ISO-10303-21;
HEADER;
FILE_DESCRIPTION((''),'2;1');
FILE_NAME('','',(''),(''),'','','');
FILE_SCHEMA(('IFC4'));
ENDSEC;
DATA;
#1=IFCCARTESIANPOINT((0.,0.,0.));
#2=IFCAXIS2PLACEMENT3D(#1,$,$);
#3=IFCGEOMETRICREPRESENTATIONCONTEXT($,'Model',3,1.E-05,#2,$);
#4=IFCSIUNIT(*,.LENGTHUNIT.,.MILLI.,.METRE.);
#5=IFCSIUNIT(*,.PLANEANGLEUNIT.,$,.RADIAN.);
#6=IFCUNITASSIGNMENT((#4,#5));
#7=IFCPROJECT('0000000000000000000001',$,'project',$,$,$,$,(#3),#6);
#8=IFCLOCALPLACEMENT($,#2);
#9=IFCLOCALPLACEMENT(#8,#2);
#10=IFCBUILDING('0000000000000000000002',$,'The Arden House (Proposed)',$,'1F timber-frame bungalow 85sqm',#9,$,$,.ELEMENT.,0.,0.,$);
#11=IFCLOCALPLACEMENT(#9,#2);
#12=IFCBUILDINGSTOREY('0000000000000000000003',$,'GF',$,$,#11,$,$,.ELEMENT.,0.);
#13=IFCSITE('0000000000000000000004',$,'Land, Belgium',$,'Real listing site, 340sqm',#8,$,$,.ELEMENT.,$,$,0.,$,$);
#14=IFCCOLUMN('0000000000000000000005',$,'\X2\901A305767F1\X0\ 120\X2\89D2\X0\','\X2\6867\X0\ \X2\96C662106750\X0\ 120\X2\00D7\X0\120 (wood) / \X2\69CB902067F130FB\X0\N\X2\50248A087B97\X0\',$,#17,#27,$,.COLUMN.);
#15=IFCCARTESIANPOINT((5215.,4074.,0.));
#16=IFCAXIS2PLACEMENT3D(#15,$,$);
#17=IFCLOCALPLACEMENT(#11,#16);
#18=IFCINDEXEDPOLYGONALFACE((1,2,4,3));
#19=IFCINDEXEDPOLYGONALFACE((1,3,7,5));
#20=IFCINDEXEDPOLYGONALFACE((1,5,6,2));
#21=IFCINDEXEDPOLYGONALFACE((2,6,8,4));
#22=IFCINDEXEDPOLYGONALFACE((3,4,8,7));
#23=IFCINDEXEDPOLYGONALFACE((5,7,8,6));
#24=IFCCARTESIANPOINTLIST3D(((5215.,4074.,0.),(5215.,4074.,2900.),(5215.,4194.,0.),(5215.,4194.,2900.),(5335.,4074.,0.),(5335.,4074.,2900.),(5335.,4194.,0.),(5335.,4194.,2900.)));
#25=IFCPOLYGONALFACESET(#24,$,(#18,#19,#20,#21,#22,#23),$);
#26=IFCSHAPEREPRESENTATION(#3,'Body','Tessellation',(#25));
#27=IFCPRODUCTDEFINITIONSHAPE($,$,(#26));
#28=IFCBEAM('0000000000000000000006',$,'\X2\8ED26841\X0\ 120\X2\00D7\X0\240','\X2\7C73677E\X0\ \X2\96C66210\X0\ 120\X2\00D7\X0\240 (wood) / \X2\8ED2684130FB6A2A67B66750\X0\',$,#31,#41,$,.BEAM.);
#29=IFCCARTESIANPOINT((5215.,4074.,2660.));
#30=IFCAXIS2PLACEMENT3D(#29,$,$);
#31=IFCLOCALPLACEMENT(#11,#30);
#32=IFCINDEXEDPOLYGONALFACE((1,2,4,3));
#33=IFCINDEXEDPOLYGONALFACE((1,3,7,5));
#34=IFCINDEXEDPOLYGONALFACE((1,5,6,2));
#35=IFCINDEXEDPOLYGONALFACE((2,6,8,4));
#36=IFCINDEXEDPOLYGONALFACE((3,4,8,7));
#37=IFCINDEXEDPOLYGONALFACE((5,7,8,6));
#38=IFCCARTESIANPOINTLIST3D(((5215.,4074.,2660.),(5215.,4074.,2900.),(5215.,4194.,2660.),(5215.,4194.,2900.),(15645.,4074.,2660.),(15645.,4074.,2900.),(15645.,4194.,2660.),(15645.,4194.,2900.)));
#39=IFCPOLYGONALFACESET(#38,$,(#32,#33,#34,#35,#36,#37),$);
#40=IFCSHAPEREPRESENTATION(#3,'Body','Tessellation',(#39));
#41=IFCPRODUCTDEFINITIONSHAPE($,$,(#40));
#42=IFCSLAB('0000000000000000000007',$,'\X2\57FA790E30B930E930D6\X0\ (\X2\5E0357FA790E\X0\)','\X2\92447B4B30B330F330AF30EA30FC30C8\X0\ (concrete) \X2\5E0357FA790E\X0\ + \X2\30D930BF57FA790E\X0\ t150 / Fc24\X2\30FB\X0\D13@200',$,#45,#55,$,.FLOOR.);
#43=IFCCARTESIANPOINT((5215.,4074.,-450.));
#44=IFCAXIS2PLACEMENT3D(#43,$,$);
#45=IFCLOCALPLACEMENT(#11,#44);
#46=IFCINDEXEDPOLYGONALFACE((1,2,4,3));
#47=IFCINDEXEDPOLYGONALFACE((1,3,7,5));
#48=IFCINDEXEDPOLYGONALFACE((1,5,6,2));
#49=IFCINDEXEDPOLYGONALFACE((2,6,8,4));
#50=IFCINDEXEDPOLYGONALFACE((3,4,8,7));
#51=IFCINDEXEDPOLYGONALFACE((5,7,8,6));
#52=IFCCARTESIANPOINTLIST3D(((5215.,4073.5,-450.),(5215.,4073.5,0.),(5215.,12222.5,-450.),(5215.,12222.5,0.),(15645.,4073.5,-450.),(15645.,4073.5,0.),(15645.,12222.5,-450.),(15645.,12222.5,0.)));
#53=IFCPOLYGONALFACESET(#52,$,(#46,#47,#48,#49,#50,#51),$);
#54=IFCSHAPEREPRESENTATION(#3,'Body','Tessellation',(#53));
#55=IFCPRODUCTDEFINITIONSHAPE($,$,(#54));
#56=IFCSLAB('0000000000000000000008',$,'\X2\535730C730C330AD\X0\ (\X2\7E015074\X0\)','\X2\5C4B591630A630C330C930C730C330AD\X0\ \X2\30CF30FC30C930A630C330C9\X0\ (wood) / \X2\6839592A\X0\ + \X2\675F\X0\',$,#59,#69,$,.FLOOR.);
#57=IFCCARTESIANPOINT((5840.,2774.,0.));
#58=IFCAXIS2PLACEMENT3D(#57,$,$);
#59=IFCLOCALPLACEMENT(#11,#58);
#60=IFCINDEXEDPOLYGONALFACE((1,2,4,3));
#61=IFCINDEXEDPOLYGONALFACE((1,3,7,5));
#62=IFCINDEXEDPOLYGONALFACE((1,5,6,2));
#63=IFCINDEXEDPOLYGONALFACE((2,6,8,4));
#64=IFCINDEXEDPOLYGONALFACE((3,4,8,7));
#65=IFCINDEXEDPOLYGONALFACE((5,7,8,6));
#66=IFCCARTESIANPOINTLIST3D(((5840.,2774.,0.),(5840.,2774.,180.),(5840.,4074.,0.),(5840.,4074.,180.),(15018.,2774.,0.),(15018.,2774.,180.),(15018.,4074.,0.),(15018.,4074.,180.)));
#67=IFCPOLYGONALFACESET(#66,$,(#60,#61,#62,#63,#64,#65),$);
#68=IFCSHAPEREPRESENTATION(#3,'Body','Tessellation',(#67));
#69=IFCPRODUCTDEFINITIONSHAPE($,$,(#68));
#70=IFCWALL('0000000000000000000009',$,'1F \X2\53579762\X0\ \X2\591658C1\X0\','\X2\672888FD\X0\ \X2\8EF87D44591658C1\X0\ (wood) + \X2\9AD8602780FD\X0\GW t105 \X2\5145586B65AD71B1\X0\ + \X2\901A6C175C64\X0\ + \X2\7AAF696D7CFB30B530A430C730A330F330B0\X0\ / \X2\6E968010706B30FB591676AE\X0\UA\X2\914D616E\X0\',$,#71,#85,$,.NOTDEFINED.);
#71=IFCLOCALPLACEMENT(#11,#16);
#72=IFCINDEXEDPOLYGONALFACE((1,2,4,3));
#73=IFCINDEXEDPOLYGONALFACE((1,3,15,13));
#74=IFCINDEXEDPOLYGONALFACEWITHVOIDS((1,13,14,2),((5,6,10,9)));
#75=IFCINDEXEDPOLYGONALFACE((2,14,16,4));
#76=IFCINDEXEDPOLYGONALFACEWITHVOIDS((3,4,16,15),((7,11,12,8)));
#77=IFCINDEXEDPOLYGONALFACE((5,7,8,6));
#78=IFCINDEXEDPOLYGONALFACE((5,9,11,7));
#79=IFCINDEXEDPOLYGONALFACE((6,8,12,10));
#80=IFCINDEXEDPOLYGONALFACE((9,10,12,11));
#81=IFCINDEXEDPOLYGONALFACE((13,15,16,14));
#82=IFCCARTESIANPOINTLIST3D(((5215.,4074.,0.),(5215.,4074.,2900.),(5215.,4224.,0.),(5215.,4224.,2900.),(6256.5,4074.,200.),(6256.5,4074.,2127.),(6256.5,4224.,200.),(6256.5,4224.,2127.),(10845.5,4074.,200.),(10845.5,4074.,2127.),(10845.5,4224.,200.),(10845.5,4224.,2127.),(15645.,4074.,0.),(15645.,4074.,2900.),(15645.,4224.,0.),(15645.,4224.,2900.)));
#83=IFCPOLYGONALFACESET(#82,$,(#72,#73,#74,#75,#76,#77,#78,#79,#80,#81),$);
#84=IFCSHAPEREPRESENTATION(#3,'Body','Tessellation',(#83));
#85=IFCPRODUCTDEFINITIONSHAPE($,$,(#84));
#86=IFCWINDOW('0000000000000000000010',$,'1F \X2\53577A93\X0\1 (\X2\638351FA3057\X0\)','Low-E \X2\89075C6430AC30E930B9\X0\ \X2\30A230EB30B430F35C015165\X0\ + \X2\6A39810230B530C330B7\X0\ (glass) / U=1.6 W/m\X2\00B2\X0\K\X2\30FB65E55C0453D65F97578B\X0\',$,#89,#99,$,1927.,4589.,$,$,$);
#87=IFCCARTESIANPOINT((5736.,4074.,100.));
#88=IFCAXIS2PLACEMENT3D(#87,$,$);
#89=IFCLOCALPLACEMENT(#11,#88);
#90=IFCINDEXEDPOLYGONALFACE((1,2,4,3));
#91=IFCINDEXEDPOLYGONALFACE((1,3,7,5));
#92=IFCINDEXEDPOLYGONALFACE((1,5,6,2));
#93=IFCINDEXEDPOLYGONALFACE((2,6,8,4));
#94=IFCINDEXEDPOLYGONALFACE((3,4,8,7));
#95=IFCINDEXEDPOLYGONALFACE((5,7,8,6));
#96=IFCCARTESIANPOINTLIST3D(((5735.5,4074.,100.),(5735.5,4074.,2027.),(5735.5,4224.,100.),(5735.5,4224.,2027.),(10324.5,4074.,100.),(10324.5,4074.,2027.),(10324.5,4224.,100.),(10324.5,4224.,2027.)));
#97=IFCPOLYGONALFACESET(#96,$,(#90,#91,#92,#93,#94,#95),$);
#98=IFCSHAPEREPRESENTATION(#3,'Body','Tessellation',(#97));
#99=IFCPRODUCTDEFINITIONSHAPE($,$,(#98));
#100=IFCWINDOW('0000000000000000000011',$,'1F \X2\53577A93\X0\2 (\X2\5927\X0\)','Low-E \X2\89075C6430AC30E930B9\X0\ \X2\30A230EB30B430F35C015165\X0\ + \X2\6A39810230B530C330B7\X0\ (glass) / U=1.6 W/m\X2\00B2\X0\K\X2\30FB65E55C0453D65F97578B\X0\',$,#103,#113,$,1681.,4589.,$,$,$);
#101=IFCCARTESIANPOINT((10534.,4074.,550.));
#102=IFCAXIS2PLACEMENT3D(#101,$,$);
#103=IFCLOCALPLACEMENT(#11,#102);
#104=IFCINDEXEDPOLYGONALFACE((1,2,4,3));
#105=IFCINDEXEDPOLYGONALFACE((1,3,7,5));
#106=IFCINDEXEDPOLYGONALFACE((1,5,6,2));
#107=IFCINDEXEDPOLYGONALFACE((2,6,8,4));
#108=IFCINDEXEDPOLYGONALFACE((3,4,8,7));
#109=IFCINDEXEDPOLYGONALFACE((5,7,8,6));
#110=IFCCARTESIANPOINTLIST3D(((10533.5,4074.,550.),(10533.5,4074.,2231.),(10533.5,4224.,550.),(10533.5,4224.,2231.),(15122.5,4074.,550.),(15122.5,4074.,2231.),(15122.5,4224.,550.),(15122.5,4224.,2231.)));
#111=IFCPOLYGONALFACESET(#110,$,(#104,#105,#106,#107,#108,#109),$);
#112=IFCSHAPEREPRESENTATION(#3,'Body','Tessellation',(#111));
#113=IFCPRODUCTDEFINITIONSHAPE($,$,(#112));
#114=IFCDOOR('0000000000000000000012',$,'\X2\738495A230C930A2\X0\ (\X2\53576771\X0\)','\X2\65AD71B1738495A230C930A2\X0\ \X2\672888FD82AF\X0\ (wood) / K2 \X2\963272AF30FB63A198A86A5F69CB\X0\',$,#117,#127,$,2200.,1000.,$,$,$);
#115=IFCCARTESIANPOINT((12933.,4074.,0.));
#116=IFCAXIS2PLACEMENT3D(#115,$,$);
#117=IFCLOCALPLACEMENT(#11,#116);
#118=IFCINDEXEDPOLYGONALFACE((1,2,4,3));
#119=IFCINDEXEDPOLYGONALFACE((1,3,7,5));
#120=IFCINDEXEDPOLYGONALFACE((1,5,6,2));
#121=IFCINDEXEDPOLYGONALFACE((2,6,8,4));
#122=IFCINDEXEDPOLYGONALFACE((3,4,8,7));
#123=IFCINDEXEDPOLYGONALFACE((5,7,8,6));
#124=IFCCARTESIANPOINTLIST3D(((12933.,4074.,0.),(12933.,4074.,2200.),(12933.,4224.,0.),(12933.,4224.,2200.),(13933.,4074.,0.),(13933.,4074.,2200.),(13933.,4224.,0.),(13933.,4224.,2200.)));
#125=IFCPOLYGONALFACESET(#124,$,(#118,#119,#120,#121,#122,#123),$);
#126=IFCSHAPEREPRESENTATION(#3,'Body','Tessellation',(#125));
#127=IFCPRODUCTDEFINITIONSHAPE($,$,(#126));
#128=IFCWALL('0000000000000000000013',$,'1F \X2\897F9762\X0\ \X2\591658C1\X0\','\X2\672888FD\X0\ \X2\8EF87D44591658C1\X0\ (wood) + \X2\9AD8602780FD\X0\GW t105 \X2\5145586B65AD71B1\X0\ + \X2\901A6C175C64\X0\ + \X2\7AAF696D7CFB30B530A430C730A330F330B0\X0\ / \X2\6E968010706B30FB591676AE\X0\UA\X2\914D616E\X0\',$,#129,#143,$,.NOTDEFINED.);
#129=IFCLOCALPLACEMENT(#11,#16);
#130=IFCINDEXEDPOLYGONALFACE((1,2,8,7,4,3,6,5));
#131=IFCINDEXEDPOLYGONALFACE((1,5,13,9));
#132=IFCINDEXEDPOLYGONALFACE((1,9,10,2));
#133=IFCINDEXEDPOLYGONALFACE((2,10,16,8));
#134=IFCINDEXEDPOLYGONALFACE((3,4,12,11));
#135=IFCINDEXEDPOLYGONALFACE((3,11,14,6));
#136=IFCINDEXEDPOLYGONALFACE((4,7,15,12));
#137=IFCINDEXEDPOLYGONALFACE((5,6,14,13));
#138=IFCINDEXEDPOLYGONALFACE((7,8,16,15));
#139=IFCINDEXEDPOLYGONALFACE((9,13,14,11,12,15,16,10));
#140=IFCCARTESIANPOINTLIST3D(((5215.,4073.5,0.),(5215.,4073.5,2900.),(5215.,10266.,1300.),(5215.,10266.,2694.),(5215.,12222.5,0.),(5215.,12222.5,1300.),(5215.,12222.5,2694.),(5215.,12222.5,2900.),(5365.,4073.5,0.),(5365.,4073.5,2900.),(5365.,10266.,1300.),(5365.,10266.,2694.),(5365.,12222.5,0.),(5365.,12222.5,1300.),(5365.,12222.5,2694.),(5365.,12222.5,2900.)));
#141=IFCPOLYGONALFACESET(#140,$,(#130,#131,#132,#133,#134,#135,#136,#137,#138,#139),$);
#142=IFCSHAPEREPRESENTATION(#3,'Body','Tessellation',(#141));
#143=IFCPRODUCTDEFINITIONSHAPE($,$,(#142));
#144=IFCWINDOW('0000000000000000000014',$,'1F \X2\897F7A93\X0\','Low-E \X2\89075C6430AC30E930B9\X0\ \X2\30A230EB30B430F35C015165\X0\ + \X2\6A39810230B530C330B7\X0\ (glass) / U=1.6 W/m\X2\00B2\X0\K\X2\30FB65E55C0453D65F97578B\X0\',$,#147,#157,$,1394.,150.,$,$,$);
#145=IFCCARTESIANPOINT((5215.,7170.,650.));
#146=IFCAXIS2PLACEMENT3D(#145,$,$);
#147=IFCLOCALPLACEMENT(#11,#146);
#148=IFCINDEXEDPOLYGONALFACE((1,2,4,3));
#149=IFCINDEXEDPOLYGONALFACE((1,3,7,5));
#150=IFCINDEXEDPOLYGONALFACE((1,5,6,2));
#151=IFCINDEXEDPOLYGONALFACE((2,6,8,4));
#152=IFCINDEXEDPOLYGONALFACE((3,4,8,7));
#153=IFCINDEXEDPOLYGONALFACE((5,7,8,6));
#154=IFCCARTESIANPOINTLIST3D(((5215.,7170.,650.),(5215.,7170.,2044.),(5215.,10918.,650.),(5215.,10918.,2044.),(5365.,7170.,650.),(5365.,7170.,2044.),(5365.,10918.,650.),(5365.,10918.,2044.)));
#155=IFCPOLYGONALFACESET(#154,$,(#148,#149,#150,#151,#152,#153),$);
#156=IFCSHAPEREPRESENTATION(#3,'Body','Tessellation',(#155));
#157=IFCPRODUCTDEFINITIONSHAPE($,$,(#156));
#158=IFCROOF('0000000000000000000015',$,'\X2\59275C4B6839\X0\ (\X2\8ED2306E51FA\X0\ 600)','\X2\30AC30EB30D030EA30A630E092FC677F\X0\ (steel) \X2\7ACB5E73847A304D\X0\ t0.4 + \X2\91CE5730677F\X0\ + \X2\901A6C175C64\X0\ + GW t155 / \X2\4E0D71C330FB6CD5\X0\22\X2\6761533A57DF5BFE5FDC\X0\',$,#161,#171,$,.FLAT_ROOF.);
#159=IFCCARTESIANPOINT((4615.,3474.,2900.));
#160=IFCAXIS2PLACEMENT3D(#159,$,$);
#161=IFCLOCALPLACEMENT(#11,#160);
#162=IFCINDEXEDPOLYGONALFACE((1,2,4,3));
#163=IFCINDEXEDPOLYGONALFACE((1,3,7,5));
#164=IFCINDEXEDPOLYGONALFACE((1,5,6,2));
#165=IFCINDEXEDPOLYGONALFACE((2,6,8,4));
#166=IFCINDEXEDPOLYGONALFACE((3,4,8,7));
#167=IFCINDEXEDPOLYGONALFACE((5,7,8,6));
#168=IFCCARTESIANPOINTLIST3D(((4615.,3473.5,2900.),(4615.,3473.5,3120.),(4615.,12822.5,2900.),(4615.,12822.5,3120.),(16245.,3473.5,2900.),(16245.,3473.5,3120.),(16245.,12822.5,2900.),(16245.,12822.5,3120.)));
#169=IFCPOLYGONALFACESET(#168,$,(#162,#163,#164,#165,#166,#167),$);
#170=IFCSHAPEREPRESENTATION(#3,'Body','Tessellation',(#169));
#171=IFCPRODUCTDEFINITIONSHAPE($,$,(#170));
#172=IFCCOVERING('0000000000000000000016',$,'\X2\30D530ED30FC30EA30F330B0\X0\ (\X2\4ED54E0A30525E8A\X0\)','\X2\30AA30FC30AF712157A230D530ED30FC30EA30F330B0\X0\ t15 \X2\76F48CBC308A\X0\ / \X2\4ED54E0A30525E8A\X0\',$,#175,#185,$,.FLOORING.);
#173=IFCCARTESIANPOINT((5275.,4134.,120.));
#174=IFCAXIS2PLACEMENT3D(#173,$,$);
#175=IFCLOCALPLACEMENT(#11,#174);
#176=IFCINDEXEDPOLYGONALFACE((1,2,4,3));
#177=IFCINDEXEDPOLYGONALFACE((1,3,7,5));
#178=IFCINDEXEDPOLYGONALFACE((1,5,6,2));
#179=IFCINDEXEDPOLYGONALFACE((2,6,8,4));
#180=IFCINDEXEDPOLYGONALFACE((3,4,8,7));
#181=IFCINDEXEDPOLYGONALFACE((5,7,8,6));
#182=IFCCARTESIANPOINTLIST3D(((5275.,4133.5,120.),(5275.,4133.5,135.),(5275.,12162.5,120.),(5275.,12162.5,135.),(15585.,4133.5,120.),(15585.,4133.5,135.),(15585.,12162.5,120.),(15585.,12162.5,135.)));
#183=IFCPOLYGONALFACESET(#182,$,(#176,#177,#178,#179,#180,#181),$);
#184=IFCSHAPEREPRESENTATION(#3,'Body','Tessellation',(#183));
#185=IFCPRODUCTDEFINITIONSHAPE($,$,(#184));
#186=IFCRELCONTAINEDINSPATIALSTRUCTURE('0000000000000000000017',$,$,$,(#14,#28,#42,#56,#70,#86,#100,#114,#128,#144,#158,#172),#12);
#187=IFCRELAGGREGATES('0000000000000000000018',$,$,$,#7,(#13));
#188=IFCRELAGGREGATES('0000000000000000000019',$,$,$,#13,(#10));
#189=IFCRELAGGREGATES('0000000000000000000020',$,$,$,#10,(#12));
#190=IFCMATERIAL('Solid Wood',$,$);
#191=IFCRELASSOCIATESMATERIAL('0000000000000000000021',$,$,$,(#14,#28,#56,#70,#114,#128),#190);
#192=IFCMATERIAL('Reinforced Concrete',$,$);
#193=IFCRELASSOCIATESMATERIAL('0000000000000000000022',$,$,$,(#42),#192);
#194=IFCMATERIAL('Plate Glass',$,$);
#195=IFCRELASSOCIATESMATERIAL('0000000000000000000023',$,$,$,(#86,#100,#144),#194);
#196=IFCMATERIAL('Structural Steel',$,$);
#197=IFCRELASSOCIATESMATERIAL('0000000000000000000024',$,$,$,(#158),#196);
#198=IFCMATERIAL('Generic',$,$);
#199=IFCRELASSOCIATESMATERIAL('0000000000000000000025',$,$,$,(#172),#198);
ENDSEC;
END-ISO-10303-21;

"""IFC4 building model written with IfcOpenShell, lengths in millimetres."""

from ifc_helpers import new_model, si_unit, frame, frame_2d, origin, place, context, project, spatial, rectangle, extrude, material, element, fill, save


model = new_model("IFC4")

# Units and contexts
model_context = context("Model", 3, precision=1e-05, world=origin())
ifc_project = project(units=[si_unit("LENGTHUNIT", "METRE", prefix="MILLI"), si_unit("PLANEANGLEUNIT", "RADIAN")], contexts=[model_context])

# Site, building, storey
site_placement = place(None, origin())
site = spatial("IfcSite", under=ifc_project, at=site_placement, Name="Land, Belgium", ObjectType="Real listing site, 340sqm", CompositionType="ELEMENT", RefElevation=0.0)
building_placement = place(site_placement, origin())
building = spatial("IfcBuilding", under=site, at=building_placement, Name="The Arden House (Proposed)", ObjectType="1F timber-frame bungalow 85sqm", CompositionType="ELEMENT", ElevationOfRefHeight=0.0, ElevationOfTerrain=0.0)
storey_placement = place(building_placement, origin())
storey = spatial("IfcBuildingStorey", under=building, at=storey_placement, Name="GF", CompositionType="ELEMENT", Elevation=0.0)

# Column
ifc_material_1 = material(Name="Solid Wood")
column_placement = place(storey_placement, frame((5215.0, 4074.0, 0.0)))
element("IfcColumn", 1, at=column_placement, inside=storey, material=ifc_material_1, Name="通し柱 120角", Description="桧 集成材 120×120 (wood) / 構造柱・N値計算", PredefinedType="COLUMN", context=model_context, shape_type="SweptSolid", body=[
    extrude(rectangle(XDim=120.0, YDim=120.0, at=frame_2d((60.0, 60.0))), frame((5215.0, 4074.0, 0.0)), (0.0, 0.0, 1.0), 2900.0),
])

# Beam
beam_1_placement = place(storey_placement, frame((5215.0, 4074.0, 2660.0)))
element("IfcBeam", 2, at=beam_1_placement, inside=storey, material=ifc_material_1, Name="軒桁 120×240", Description="米松 集成 120×240 (wood) / 軒桁・横架材", PredefinedType="BEAM", context=model_context, shape_type="SweptSolid", body=[
    extrude(rectangle(XDim=10430.0, YDim=120.0, at=frame_2d((5215.0, 60.0))), frame((5215.0, 4074.0, 2660.0)), (0.0, 0.0, 1.0), 240.0),
])

# Slabs
ifc_material_2 = material(Name="Reinforced Concrete")
slab_1_placement = place(storey_placement, frame((5215.0, 4074.0, -450.0)))
element("IfcSlab", 3, at=slab_1_placement, inside=storey, material=ifc_material_2, Name="基礎スラブ (布基礎)", Description="鉄筋コンクリート (concrete) 布基礎 + ベタ基礎 t150 / Fc24・D13@200", PredefinedType="FLOOR", context=model_context, shape_type="SweptSolid", body=[
    extrude(rectangle(XDim=10430.0, YDim=8149.0, at=frame_2d((5215.0, 4074.0))), frame((5215.0, 4074.0, -450.0)), (0.0, 0.0, 1.0), 450.0),
])
slab_2_placement = place(storey_placement, frame((5840.0, 2774.0, 0.0)))
element("IfcSlab", 4, at=slab_2_placement, inside=storey, material=ifc_material_1, Name="南デッキ (縁側)", Description="屋外ウッドデッキ ハードウッド (wood) / 根太 + 束", PredefinedType="FLOOR", context=model_context, shape_type="SweptSolid", body=[
    extrude(rectangle(XDim=9178.0, YDim=1300.0, at=frame_2d((4589.0, 650.0))), frame((5840.0, 2774.0, 0.0)), (0.0, 0.0, 1.0), 180.0),
])

# Wall, openings, windows, door
wall_1_placement = place(storey_placement, frame((5215.0, 4074.0, 0.0)))
wall_1 = element("IfcWall", 5, at=wall_1_placement, inside=storey, material=ifc_material_1, Name="1F 南面 外壁", Description="木製 軸組外壁 (wood) + 高性能GW t105 充填断熱 + 通気層 + 窯業系サイディング / 準耐火・外皮UA配慮", PredefinedType="NOTDEFINED", context=model_context, shape_type="SweptSolid", body=[
    extrude(rectangle(XDim=10430.0, YDim=150.0, at=frame_2d((5215.0, 75.0))), frame((5215.0, 4074.0, 0.0)), (0.0, 0.0, 1.0), 2900.0),
])
opening_1_placement = place(storey_placement, frame((5736.0, 4074.0, 100.0)))
opening_1 = element("IfcOpeningElement", 6, at=opening_1_placement, cuts=wall_1, PredefinedType="NOTDEFINED", context=model_context, shape_type="SweptSolid", body=[
    extrude(rectangle(XDim=4589.0, YDim=150.0, at=frame_2d((2294.0, 75.0))), frame((5736.0, 4074.0, 100.0)), (0.0, 0.0, 1.0), 1927.0),
])
opening_2_placement = place(storey_placement, frame((10534.0, 4074.0, 550.0)))
opening_2 = element("IfcOpeningElement", 7, at=opening_2_placement, cuts=wall_1, PredefinedType="NOTDEFINED", context=model_context, shape_type="SweptSolid", body=[
    extrude(rectangle(XDim=4589.0, YDim=150.0, at=frame_2d((2294.0, 75.0))), frame((10534.0, 4074.0, 550.0)), (0.0, 0.0, 1.0), 1681.0),
])
opening_3_placement = place(storey_placement, frame((12933.0, 4074.0, 0.0)))
opening_3 = element("IfcOpeningElement", 8, at=opening_3_placement, cuts=wall_1, PredefinedType="NOTDEFINED", context=model_context, shape_type="SweptSolid", body=[
    extrude(rectangle(XDim=1000.0, YDim=150.0, at=frame_2d((500.0, 75.0))), frame((12933.0, 4074.0, 0.0)), (0.0, 0.0, 1.0), 2200.0),
])
ifc_material_3 = material(Name="Plate Glass")
window_1_placement = place(storey_placement, frame((5736.0, 4074.0, 100.0)))
window_1 = element("IfcWindow", 9, at=window_1_placement, inside=storey, material=ifc_material_3, Name="1F 南窓1 (掃出し)", Description="Low-E 複層ガラス アルゴン封入 + 樹脂サッシ (glass) / U=1.6 W/m²K・日射取得型", OverallHeight=1927.0, OverallWidth=4589.0, context=model_context, shape_type="SweptSolid", body=[
    extrude(rectangle(XDim=4589.0, YDim=150.0, at=frame_2d((2294.0, 75.0))), frame((5736.0, 4074.0, 100.0)), (0.0, 0.0, 1.0), 1927.0),
])
fill(opening_1, window_1)
window_2_placement = place(storey_placement, frame((10534.0, 4074.0, 550.0)))
window_2 = element("IfcWindow", 10, at=window_2_placement, inside=storey, material=ifc_material_3, Name="1F 南窓2 (大)", Description="Low-E 複層ガラス アルゴン封入 + 樹脂サッシ (glass) / U=1.6 W/m²K・日射取得型", OverallHeight=1681.0, OverallWidth=4589.0, context=model_context, shape_type="SweptSolid", body=[
    extrude(rectangle(XDim=4589.0, YDim=150.0, at=frame_2d((2294.0, 75.0))), frame((10534.0, 4074.0, 550.0)), (0.0, 0.0, 1.0), 1681.0),
])
fill(opening_2, window_2)
door_placement = place(storey_placement, frame((12933.0, 4074.0, 0.0)))
door = element("IfcDoor", 11, at=door_placement, inside=storey, material=ifc_material_1, Name="玄関ドア (南東)", Description="断熱玄関ドア 木製芯 (wood) / K2 防犯・採風機構", OverallHeight=2200.0, OverallWidth=1000.0, context=model_context, shape_type="SweptSolid", body=[
    extrude(rectangle(XDim=1000.0, YDim=150.0, at=frame_2d((500.0, 75.0))), frame((12933.0, 4074.0, 0.0)), (0.0, 0.0, 1.0), 2200.0),
])
fill(opening_3, door)

# Wall, opening, window
wall_2_placement = place(storey_placement, frame((5215.0, 4074.0, 0.0)))
wall_2 = element("IfcWall", 12, at=wall_2_placement, inside=storey, material=ifc_material_1, Name="1F 西面 外壁", Description="木製 軸組外壁 (wood) + 高性能GW t105 充填断熱 + 通気層 + 窯業系サイディング / 準耐火・外皮UA配慮", PredefinedType="NOTDEFINED", context=model_context, shape_type="SweptSolid", body=[
    extrude(rectangle(XDim=150.0, YDim=8149.0, at=frame_2d((75.0, 4074.0))), frame((5215.0, 4074.0, 0.0)), (0.0, 0.0, 1.0), 2900.0),
])
opening_4_placement = place(storey_placement, frame((5215.0, 7170.0, 650.0)))
opening_4 = element("IfcOpeningElement", 13, at=opening_4_placement, cuts=wall_2, PredefinedType="NOTDEFINED", context=model_context, shape_type="SweptSolid", body=[
    extrude(rectangle(XDim=150.0, YDim=3748.0, at=frame_2d((75.0, 1874.0))), frame((5215.0, 7170.0, 650.0)), (0.0, 0.0, 1.0), 1394.0),
])
window_3_placement = place(storey_placement, frame((5215.0, 7170.0, 650.0)))
window_3 = element("IfcWindow", 14, at=window_3_placement, inside=storey, material=ifc_material_3, Name="1F 西窓", Description="Low-E 複層ガラス アルゴン封入 + 樹脂サッシ (glass) / U=1.6 W/m²K・日射取得型", OverallHeight=1394.0, OverallWidth=150.0, context=model_context, shape_type="SweptSolid", body=[
    extrude(rectangle(XDim=150.0, YDim=3748.0, at=frame_2d((75.0, 1874.0))), frame((5215.0, 7170.0, 650.0)), (0.0, 0.0, 1.0), 1394.0),
])
fill(opening_4, window_3)

# Roof
ifc_material_4 = material(Name="Structural Steel")
roof_placement = place(storey_placement, frame((4615.0, 3474.0, 2900.0)))
element("IfcRoof", 15, at=roof_placement, inside=storey, material=ifc_material_4, Name="大屋根 (軒の出 600)", Description="ガルバリウム鋼板 (steel) 立平葺き t0.4 + 野地板 + 通気層 + GW t155 / 不燃・法22条区域対応", PredefinedType="FLAT_ROOF", context=model_context, shape_type="SweptSolid", body=[
    extrude(rectangle(XDim=11630.0, YDim=9349.0, at=frame_2d((5815.0, 4674.0))), frame((4615.0, 3474.0, 2900.0)), (0.0, 0.0, 1.0), 220.0),
])

# Covering
ifc_material_5 = material(Name="Generic")
covering_1_placement = place(storey_placement, frame((5275.0, 4134.0, 120.0)))
element("IfcCovering", 16, at=covering_1_placement, inside=storey, material=ifc_material_5, Name="フローリング (仕上げ床)", Description="オーク無垢フローリング t15 直貼り / 仕上げ床", PredefinedType="FLOORING", context=model_context, shape_type="SweptSolid", body=[
    extrude(rectangle(XDim=10310.0, YDim=8029.0, at=frame_2d((5155.0, 4014.0))), frame((5275.0, 4134.0, 120.0)), (0.0, 0.0, 1.0), 15.0),
])

save(model, "model.ifc")
